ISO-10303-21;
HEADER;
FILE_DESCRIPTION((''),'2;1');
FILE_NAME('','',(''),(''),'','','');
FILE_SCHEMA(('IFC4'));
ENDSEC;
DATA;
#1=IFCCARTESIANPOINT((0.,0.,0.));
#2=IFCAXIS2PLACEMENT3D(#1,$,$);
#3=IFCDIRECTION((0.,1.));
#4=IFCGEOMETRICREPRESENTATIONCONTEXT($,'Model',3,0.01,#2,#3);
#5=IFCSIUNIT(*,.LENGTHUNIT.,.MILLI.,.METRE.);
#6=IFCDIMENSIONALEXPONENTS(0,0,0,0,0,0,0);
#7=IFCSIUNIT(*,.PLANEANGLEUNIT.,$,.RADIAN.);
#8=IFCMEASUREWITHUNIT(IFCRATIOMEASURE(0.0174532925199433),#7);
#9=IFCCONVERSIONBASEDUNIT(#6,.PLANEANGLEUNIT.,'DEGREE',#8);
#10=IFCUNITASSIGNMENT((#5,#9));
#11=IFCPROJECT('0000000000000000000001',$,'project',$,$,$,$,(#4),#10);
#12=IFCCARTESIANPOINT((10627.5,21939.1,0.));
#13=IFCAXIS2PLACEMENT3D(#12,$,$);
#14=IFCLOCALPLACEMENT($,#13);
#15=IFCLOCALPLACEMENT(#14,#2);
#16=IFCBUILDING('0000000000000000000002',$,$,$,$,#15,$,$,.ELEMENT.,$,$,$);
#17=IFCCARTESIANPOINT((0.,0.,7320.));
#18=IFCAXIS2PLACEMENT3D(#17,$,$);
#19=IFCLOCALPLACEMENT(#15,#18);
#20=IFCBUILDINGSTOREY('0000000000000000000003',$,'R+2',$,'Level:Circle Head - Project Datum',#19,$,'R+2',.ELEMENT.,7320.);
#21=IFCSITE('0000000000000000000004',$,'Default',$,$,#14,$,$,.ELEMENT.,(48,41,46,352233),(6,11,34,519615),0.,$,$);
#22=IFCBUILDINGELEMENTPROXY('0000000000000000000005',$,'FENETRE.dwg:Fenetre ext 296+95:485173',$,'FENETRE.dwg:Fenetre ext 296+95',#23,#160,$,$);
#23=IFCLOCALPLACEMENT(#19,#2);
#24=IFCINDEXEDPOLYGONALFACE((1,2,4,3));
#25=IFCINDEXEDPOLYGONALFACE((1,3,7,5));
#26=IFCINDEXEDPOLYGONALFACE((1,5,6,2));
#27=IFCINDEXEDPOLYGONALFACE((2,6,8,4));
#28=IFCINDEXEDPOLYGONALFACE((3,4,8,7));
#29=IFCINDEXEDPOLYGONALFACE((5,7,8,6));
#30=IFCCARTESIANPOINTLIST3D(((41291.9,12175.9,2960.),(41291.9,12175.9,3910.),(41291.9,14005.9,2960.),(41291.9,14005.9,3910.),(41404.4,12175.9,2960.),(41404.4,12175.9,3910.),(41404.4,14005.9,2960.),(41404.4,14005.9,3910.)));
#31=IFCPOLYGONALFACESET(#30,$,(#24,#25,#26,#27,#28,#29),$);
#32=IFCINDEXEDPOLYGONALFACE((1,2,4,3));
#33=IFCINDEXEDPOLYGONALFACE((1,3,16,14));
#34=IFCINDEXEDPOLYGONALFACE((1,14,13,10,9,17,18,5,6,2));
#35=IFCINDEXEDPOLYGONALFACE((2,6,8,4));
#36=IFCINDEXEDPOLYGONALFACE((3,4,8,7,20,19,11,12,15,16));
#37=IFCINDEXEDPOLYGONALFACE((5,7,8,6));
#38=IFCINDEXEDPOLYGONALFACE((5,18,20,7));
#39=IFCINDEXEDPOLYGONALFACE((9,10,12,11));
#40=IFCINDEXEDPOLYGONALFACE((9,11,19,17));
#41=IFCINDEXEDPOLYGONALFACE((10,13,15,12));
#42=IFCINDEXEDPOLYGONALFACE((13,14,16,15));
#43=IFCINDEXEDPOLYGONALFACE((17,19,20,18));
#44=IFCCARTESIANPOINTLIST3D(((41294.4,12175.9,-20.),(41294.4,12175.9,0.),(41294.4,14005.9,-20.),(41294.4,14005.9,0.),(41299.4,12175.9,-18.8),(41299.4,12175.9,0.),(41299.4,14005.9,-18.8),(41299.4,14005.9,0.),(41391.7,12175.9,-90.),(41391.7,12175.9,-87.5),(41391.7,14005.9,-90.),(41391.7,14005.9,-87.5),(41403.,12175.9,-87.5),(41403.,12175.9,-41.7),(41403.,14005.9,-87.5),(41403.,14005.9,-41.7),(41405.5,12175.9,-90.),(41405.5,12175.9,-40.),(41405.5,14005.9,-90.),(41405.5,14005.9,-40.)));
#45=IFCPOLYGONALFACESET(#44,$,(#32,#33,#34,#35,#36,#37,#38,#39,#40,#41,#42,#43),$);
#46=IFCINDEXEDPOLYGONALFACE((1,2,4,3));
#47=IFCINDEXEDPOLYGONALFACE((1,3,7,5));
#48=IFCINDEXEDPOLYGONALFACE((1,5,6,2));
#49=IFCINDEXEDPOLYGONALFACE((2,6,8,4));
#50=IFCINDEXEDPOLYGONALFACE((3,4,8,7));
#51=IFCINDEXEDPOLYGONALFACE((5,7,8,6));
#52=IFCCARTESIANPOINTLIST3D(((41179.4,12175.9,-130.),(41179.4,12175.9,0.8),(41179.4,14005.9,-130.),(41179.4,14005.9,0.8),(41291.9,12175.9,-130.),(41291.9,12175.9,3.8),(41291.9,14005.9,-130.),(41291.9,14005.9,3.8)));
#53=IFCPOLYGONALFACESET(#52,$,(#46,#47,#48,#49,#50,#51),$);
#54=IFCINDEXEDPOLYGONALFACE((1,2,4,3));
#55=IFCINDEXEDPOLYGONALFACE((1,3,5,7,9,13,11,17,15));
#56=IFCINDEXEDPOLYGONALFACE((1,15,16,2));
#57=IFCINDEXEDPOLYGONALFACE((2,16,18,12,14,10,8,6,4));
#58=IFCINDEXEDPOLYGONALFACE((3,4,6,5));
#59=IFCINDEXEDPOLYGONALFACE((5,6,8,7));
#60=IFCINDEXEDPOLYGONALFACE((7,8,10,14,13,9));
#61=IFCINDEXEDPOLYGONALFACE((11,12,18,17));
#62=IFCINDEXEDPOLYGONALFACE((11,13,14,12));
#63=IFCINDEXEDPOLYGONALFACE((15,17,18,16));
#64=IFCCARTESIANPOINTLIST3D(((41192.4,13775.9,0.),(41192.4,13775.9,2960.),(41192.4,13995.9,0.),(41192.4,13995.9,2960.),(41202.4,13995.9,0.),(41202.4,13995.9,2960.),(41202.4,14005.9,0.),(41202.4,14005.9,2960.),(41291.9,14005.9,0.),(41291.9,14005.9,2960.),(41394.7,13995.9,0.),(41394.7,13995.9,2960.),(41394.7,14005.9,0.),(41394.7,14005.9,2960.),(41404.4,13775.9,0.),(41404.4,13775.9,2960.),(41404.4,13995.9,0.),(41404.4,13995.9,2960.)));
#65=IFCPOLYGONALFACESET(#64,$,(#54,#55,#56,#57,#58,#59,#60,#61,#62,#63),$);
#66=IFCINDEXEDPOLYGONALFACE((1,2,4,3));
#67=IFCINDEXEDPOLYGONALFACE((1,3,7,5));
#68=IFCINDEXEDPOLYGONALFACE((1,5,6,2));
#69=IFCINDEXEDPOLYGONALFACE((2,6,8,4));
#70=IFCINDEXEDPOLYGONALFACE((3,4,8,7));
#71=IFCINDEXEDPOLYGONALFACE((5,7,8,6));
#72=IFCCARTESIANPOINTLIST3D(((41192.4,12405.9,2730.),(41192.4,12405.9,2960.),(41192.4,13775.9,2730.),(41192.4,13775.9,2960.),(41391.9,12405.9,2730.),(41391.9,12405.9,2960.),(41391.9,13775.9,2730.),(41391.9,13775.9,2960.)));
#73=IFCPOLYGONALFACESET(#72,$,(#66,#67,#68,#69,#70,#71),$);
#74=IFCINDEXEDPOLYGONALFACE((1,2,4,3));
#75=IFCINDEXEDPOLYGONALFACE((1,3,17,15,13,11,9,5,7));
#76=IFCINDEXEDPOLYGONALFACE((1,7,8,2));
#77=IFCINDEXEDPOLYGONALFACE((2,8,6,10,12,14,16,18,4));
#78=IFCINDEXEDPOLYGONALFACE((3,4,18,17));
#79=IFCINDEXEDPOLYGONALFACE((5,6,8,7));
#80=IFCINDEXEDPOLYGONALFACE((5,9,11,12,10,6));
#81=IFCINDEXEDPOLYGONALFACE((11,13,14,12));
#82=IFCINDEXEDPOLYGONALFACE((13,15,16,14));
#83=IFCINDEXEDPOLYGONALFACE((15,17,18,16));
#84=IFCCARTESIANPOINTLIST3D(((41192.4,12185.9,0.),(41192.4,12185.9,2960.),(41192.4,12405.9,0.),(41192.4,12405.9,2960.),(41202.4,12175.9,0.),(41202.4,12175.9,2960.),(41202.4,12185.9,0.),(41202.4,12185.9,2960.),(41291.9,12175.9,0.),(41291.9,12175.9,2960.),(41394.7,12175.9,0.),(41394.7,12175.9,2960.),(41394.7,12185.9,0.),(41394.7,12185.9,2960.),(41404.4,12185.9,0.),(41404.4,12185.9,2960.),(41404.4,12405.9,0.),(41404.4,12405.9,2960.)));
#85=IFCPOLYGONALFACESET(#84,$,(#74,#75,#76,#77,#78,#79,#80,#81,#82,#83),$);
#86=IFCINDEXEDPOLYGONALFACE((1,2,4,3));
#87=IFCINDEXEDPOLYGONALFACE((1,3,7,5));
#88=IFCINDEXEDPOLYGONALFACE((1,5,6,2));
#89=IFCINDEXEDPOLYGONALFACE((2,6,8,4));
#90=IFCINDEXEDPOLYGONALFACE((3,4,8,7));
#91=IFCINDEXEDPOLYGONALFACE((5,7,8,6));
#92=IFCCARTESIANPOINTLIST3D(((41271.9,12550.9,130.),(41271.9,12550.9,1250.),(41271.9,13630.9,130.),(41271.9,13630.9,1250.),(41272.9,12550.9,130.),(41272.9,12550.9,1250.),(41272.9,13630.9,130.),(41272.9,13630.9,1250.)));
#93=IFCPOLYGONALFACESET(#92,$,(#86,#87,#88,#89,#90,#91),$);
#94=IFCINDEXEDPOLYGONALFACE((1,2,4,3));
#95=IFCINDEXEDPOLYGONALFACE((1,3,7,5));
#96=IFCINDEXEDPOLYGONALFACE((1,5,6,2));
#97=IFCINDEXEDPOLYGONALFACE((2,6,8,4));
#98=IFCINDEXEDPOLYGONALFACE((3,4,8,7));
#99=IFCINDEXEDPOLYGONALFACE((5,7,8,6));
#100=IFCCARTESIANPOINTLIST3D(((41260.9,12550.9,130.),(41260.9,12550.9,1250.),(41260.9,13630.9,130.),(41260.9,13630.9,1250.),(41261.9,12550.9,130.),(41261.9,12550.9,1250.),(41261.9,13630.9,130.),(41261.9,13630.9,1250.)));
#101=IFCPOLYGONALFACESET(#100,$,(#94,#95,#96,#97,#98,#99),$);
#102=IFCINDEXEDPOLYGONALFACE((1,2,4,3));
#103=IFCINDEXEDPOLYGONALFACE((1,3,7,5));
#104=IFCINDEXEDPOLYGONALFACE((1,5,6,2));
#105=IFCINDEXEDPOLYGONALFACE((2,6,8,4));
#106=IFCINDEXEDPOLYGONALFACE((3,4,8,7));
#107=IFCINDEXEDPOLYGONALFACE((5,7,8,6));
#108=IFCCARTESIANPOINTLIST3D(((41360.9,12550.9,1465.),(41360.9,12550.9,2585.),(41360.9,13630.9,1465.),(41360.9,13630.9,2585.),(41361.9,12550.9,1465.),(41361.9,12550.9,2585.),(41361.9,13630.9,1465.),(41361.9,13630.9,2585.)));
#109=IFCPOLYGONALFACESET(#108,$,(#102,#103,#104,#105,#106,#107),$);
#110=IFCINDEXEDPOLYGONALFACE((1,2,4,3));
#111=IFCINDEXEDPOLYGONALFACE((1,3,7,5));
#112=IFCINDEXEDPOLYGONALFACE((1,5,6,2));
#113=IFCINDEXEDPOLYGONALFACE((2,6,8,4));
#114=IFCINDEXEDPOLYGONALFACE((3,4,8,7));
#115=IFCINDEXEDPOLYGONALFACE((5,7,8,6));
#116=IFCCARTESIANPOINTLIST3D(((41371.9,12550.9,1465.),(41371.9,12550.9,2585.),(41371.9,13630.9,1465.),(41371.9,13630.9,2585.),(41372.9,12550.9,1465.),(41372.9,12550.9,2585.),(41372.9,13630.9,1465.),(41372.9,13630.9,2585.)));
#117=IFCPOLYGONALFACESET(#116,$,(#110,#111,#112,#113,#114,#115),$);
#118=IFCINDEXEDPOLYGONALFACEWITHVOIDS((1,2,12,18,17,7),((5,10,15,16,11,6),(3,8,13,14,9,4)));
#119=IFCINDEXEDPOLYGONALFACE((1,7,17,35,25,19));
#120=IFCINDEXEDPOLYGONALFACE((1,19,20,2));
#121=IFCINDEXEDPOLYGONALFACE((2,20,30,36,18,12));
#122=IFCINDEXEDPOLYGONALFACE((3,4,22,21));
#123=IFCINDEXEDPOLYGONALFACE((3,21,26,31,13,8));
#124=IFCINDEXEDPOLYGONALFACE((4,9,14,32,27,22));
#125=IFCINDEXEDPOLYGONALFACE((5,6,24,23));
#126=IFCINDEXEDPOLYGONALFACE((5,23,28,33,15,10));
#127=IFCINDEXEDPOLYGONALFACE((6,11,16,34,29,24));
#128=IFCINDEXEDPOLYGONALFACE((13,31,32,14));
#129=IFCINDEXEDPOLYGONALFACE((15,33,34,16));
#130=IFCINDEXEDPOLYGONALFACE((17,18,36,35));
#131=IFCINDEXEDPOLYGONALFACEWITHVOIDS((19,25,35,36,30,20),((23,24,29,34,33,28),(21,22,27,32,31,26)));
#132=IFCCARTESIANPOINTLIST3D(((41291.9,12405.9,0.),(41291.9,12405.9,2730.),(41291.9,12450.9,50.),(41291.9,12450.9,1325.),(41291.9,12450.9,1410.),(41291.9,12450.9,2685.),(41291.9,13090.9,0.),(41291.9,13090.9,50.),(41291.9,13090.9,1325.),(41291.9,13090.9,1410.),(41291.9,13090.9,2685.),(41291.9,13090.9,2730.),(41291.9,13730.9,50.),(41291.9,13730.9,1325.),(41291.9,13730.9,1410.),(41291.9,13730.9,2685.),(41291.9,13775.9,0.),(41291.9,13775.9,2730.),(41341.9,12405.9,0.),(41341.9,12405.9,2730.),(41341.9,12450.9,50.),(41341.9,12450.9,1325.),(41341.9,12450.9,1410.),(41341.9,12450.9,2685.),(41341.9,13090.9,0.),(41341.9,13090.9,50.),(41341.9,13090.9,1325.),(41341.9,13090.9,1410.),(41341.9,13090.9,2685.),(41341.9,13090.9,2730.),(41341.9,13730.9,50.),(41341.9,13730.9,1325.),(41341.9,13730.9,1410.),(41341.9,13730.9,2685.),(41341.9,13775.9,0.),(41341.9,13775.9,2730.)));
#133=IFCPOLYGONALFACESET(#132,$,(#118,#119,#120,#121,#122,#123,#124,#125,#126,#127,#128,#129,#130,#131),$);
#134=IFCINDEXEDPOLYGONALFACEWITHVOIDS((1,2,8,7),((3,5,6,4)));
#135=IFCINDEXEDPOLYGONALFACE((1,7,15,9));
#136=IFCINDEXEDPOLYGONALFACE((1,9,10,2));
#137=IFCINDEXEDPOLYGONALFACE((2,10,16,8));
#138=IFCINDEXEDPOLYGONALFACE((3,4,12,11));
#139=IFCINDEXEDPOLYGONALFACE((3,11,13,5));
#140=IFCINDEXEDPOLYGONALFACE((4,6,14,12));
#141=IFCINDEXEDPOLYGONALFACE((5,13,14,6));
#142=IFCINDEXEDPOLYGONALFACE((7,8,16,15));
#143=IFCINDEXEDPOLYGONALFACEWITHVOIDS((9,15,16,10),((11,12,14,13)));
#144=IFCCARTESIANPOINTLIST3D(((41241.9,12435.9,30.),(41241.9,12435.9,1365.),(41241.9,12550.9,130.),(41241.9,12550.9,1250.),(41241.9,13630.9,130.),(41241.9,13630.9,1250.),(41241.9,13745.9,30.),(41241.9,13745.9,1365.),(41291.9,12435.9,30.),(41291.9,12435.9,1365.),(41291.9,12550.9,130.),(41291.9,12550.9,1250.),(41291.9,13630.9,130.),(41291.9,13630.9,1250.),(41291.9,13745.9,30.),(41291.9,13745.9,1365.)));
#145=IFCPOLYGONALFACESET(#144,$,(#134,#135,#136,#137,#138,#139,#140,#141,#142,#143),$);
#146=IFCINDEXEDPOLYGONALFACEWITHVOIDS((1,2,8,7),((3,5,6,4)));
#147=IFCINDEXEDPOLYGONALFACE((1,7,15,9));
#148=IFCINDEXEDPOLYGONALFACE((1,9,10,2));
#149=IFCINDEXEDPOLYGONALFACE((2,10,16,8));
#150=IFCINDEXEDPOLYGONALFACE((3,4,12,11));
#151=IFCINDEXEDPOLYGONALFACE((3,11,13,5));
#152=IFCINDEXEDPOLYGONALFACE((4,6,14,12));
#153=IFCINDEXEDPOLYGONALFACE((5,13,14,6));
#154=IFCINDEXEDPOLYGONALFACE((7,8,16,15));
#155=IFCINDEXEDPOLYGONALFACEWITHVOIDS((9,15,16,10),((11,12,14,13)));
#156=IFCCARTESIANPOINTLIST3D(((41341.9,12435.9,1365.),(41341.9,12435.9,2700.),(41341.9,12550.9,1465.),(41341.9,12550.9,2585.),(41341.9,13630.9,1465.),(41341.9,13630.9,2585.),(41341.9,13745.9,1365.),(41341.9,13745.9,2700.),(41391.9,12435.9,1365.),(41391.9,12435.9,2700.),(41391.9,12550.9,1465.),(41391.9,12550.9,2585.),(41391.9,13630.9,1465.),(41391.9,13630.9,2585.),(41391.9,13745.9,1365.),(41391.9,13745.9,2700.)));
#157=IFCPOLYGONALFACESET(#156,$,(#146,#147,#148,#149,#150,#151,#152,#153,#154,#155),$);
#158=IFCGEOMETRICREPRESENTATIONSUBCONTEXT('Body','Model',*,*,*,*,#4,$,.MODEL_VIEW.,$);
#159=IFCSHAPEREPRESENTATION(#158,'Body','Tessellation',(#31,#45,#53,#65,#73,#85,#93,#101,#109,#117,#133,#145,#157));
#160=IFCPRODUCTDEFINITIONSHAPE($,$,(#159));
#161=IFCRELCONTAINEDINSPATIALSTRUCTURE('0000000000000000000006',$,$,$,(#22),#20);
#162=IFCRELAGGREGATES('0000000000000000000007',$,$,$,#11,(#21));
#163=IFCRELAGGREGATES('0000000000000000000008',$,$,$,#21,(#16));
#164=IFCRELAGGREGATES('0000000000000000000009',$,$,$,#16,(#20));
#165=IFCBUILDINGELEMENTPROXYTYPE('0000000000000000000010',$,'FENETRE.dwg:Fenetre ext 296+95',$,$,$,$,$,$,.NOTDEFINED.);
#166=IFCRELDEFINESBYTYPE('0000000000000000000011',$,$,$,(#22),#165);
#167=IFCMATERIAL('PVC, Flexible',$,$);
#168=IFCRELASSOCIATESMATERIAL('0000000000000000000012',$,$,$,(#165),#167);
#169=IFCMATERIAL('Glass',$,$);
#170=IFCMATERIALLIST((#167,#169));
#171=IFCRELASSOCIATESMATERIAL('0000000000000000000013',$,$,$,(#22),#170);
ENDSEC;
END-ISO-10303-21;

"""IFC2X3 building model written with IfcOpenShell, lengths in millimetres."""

from ifc_helpers import new_model, entity, si_unit, converted_unit, direction, frame, frame_2d, origin, origin_2d_with_axis, place, context, subcontext, project, spatial, polyline, rectangle, outline, extrude, source, transform, mapped, material, material_list, type_object, type_shapes, element, save


model = new_model("IFC2X3")

# Units and contexts
model_context = context("Model", 3, precision=0.01, world=origin(), true_north=direction((0.0, 1.0)))
body_context = subcontext(model_context, "Body", "Model", "MODEL_VIEW")
ifc_project = project(units=[si_unit("LENGTHUNIT", "METRE", prefix="MILLI"), converted_unit("PLANEANGLEUNIT", "DEGREE", entity("IfcRatioMeasure", 0.0174532925199433), si_unit("PLANEANGLEUNIT", "RADIAN"), dimensions=[0, 0, 0, 0, 0, 0, 0])], contexts=[model_context])

# Site, building, storey
site_placement = place(None, frame((10627.5, 21939.1, 0.0)))
site = spatial("IfcSite", under=ifc_project, at=site_placement, Name="Default", CompositionType="ELEMENT", RefLatitude=(48, 41, 46, 352233), RefLongitude=(6, 11, 34, 519615), RefElevation=0.0)
building_placement = place(site_placement, origin())
building = spatial("IfcBuilding", under=site, at=building_placement, CompositionType="ELEMENT")
storey_placement = place(building_placement, frame((0.0, 0.0, 7320.0)))
storey = spatial("IfcBuildingStorey", under=building, at=storey_placement, Name="R+2", ObjectType="Level:Circle Head - Project Datum", LongName="R+2", CompositionType="ELEMENT", Elevation=7320.0)

# Building element proxy
ifc_material_1 = material(Name="PVC, Flexible")
ifc_material_2 = material(Name="Glass")
building_element_proxy_type_1 = type_object("IfcBuildingElementProxyType", Name="FENETRE.dwg:Fenetre ext 296+95", PredefinedType="NOTDEFINED", material=ifc_material_1)
shared_shape_1 = source(origin(), body_context, "Body", "SweptSolid", [
    extrude(rectangle(XDim=112.5, YDim=1830.0, at=origin_2d_with_axis()), frame((-10.4, -56.3, 2960.0), z_axis=(0.0, 0.0, 1.0), x_axis=(0.0, 1.0, 0.0)), (0.0, 0.0, 1.0), 950.0),
    extrude(outline(polyline([(27.5, -64.4), (47.5, -64.4), (47.5, -59.4), (28.8, -59.4), (7.5, 46.7), (-42.5, 46.7), (-42.5, 32.9), (-40.0, 32.9), (-40.0, 44.2), (5.8, 44.2), (27.5, -64.4)])), frame((-925.4, -66.9, -47.5), z_axis=(1.0, 0.0, 0.0), x_axis=(0.0, 0.0, 1.0)), (0.0, 0.0, 1.0), 1830.0),
    extrude(outline(polyline([(-54.5, -66.1), (58.0, -66.1), (54.5, 67.6), (-58.0, 64.6), (-54.5, -66.1)])), frame((-925.4, 56.3, -63.8), z_axis=(1.0, 0.0, 0.0), x_axis=(0.0, -0.999645, 0.02665)), (0.0, 0.0, 1.0), 1830.0),
    extrude(outline(polyline([(-97.0, -55.6), (5.9, -55.6), (95.4, -55.6), (95.4, -45.6), (105.4, -45.6), (105.4, 174.4), (-106.6, 174.4), (-106.6, -45.6), (-97.0, -45.6), (-97.0, -55.6)])), frame((849.0, -5.9, 0.0), z_axis=(0.0, 0.0, 1.0), x_axis=(0.0, 1.0, 0.0)), (0.0, 0.0, 1.0), 2960.0),
    extrude(rectangle(XDim=1370.0, YDim=199.5, at=origin_2d_with_axis()), frame((-10.4, -0.3, 2730.0), z_axis=(0.0, 0.0, 1.0), x_axis=(-1.0, 0.0, 0.0)), (0.0, 0.0, 1.0), 230.0),
    extrude(outline(polyline([(-55.6, 97.0), (-55.6, -5.9), (-55.6, -95.4), (-45.6, -95.4), (-45.6, -105.4), (174.4, -105.4), (174.4, 106.6), (-45.6, 106.6), (-45.6, 97.0), (-55.6, 97.0)])), frame((-869.9, -5.9, 0.0), z_axis=(0.0, 0.0, -1.0), x_axis=(1.0, 0.0, 0.0)), (0.0, 0.0, -1.0), 2960.0),
    extrude(rectangle(XDim=1080.0, YDim=1.0, at=origin_2d_with_axis()), frame((-10.4, 19.5, 130.0), z_axis=(0.0, 0.0, 1.0), x_axis=(-1.0, 0.0, 0.0)), (0.0, 0.0, 1.0), 1120.0),
    extrude(rectangle(XDim=1080.0, YDim=1.0, at=origin_2d_with_axis()), frame((-10.4, 30.5, 130.0), z_axis=(0.0, 0.0, 1.0), x_axis=(-1.0, 0.0, 0.0)), (0.0, 0.0, 1.0), 1120.0),
    extrude(rectangle(XDim=1080.0, YDim=1.0, at=frame_2d((0.0, 0.0), x_axis=(1.0, 0.0))), frame((-10.4, -69.5, 1465.0), z_axis=(0.0, 0.0, 1.0), x_axis=(-1.0, 0.0, 0.0)), (0.0, 0.0, 1.0), 1120.0),
    extrude(rectangle(XDim=1080.0, YDim=1.0, at=frame_2d((0.0, 0.0), x_axis=(1.0, 0.0))), frame((-10.4, -80.5, 1465.0), z_axis=(0.0, 0.0, 1.0), x_axis=(-1.0, 0.0, 0.0)), (0.0, 0.0, 1.0), 1120.0),
    extrude(outline(polyline([(-685.0, -1365.0), (0.0, -1365.0), (685.0, -1365.0), (685.0, 1365.0), (0.0, 1365.0), (-685.0, 1365.0), (-685.0, -1365.0)]), holes=[polyline([(-640.0, -1320.0), (-640.0, -45.0), (0.0, -45.0), (640.0, -45.0), (640.0, -1320.0), (0.0, -1320.0), (-640.0, -1320.0)]), polyline([(-640.0, 40.0), (-640.0, 1315.0), (0.0, 1315.0), (640.0, 1315.0), (640.0, 40.0), (0.0, 40.0), (-640.0, 40.0)])]), frame((-10.4, -50.0, 1365.0), z_axis=(0.0, 1.0, 0.0), x_axis=(1.0, 0.0, 0.0)), (0.0, 0.0, 1.0), 50.0),
    extrude(outline(polyline([(-655.0, -667.5), (655.0, -667.5), (655.0, 667.5), (-655.0, 667.5), (-655.0, -667.5)]), holes=[polyline([(-540.0, 552.5), (540.0, 552.5), (540.0, -567.5), (-540.0, -567.5), (-540.0, 552.5)])]), frame((-10.4, 0.0, 697.5), z_axis=(0.0, 1.0, 0.0), x_axis=(-1.0, 0.0, 0.0)), (0.0, 0.0, 1.0), 50.0),
    extrude(outline(polyline([(-655.0, -667.5), (655.0, -667.5), (655.0, 667.5), (-655.0, 667.5), (-655.0, -667.5)]), holes=[polyline([(-540.0, 552.5), (540.0, 552.5), (540.0, -567.5), (-540.0, -567.5), (-540.0, 552.5)])]), frame((-10.4, -100.0, 2032.5), z_axis=(0.0, 1.0, 0.0), x_axis=(-1.0, 0.0, 0.0)), (0.0, 0.0, 1.0), 50.0),
])
type_shapes(building_element_proxy_type_1, [shared_shape_1])
ifc_material_list_1 = material_list([ifc_material_1, ifc_material_2])
proxy_1_placement = place(storey_placement, frame((41291.9, 13101.3, 0.0), z_axis=(0.0, 0.0, 1.0), x_axis=(0.0, 1.0, 0.0)))
element("IfcBuildingElementProxy", 1, at=proxy_1_placement, inside=storey, type_object=building_element_proxy_type_1, material=ifc_material_list_1, Name="FENETRE.dwg:Fenetre ext 296+95:485173", ObjectType="FENETRE.dwg:Fenetre ext 296+95", context=body_context, shape_type="MappedRepresentation", body=[
    mapped(shared_shape_1, transform((0.0, 0.0, 0.0), scale=1.0)),
])

save(model, "model.ifc")
